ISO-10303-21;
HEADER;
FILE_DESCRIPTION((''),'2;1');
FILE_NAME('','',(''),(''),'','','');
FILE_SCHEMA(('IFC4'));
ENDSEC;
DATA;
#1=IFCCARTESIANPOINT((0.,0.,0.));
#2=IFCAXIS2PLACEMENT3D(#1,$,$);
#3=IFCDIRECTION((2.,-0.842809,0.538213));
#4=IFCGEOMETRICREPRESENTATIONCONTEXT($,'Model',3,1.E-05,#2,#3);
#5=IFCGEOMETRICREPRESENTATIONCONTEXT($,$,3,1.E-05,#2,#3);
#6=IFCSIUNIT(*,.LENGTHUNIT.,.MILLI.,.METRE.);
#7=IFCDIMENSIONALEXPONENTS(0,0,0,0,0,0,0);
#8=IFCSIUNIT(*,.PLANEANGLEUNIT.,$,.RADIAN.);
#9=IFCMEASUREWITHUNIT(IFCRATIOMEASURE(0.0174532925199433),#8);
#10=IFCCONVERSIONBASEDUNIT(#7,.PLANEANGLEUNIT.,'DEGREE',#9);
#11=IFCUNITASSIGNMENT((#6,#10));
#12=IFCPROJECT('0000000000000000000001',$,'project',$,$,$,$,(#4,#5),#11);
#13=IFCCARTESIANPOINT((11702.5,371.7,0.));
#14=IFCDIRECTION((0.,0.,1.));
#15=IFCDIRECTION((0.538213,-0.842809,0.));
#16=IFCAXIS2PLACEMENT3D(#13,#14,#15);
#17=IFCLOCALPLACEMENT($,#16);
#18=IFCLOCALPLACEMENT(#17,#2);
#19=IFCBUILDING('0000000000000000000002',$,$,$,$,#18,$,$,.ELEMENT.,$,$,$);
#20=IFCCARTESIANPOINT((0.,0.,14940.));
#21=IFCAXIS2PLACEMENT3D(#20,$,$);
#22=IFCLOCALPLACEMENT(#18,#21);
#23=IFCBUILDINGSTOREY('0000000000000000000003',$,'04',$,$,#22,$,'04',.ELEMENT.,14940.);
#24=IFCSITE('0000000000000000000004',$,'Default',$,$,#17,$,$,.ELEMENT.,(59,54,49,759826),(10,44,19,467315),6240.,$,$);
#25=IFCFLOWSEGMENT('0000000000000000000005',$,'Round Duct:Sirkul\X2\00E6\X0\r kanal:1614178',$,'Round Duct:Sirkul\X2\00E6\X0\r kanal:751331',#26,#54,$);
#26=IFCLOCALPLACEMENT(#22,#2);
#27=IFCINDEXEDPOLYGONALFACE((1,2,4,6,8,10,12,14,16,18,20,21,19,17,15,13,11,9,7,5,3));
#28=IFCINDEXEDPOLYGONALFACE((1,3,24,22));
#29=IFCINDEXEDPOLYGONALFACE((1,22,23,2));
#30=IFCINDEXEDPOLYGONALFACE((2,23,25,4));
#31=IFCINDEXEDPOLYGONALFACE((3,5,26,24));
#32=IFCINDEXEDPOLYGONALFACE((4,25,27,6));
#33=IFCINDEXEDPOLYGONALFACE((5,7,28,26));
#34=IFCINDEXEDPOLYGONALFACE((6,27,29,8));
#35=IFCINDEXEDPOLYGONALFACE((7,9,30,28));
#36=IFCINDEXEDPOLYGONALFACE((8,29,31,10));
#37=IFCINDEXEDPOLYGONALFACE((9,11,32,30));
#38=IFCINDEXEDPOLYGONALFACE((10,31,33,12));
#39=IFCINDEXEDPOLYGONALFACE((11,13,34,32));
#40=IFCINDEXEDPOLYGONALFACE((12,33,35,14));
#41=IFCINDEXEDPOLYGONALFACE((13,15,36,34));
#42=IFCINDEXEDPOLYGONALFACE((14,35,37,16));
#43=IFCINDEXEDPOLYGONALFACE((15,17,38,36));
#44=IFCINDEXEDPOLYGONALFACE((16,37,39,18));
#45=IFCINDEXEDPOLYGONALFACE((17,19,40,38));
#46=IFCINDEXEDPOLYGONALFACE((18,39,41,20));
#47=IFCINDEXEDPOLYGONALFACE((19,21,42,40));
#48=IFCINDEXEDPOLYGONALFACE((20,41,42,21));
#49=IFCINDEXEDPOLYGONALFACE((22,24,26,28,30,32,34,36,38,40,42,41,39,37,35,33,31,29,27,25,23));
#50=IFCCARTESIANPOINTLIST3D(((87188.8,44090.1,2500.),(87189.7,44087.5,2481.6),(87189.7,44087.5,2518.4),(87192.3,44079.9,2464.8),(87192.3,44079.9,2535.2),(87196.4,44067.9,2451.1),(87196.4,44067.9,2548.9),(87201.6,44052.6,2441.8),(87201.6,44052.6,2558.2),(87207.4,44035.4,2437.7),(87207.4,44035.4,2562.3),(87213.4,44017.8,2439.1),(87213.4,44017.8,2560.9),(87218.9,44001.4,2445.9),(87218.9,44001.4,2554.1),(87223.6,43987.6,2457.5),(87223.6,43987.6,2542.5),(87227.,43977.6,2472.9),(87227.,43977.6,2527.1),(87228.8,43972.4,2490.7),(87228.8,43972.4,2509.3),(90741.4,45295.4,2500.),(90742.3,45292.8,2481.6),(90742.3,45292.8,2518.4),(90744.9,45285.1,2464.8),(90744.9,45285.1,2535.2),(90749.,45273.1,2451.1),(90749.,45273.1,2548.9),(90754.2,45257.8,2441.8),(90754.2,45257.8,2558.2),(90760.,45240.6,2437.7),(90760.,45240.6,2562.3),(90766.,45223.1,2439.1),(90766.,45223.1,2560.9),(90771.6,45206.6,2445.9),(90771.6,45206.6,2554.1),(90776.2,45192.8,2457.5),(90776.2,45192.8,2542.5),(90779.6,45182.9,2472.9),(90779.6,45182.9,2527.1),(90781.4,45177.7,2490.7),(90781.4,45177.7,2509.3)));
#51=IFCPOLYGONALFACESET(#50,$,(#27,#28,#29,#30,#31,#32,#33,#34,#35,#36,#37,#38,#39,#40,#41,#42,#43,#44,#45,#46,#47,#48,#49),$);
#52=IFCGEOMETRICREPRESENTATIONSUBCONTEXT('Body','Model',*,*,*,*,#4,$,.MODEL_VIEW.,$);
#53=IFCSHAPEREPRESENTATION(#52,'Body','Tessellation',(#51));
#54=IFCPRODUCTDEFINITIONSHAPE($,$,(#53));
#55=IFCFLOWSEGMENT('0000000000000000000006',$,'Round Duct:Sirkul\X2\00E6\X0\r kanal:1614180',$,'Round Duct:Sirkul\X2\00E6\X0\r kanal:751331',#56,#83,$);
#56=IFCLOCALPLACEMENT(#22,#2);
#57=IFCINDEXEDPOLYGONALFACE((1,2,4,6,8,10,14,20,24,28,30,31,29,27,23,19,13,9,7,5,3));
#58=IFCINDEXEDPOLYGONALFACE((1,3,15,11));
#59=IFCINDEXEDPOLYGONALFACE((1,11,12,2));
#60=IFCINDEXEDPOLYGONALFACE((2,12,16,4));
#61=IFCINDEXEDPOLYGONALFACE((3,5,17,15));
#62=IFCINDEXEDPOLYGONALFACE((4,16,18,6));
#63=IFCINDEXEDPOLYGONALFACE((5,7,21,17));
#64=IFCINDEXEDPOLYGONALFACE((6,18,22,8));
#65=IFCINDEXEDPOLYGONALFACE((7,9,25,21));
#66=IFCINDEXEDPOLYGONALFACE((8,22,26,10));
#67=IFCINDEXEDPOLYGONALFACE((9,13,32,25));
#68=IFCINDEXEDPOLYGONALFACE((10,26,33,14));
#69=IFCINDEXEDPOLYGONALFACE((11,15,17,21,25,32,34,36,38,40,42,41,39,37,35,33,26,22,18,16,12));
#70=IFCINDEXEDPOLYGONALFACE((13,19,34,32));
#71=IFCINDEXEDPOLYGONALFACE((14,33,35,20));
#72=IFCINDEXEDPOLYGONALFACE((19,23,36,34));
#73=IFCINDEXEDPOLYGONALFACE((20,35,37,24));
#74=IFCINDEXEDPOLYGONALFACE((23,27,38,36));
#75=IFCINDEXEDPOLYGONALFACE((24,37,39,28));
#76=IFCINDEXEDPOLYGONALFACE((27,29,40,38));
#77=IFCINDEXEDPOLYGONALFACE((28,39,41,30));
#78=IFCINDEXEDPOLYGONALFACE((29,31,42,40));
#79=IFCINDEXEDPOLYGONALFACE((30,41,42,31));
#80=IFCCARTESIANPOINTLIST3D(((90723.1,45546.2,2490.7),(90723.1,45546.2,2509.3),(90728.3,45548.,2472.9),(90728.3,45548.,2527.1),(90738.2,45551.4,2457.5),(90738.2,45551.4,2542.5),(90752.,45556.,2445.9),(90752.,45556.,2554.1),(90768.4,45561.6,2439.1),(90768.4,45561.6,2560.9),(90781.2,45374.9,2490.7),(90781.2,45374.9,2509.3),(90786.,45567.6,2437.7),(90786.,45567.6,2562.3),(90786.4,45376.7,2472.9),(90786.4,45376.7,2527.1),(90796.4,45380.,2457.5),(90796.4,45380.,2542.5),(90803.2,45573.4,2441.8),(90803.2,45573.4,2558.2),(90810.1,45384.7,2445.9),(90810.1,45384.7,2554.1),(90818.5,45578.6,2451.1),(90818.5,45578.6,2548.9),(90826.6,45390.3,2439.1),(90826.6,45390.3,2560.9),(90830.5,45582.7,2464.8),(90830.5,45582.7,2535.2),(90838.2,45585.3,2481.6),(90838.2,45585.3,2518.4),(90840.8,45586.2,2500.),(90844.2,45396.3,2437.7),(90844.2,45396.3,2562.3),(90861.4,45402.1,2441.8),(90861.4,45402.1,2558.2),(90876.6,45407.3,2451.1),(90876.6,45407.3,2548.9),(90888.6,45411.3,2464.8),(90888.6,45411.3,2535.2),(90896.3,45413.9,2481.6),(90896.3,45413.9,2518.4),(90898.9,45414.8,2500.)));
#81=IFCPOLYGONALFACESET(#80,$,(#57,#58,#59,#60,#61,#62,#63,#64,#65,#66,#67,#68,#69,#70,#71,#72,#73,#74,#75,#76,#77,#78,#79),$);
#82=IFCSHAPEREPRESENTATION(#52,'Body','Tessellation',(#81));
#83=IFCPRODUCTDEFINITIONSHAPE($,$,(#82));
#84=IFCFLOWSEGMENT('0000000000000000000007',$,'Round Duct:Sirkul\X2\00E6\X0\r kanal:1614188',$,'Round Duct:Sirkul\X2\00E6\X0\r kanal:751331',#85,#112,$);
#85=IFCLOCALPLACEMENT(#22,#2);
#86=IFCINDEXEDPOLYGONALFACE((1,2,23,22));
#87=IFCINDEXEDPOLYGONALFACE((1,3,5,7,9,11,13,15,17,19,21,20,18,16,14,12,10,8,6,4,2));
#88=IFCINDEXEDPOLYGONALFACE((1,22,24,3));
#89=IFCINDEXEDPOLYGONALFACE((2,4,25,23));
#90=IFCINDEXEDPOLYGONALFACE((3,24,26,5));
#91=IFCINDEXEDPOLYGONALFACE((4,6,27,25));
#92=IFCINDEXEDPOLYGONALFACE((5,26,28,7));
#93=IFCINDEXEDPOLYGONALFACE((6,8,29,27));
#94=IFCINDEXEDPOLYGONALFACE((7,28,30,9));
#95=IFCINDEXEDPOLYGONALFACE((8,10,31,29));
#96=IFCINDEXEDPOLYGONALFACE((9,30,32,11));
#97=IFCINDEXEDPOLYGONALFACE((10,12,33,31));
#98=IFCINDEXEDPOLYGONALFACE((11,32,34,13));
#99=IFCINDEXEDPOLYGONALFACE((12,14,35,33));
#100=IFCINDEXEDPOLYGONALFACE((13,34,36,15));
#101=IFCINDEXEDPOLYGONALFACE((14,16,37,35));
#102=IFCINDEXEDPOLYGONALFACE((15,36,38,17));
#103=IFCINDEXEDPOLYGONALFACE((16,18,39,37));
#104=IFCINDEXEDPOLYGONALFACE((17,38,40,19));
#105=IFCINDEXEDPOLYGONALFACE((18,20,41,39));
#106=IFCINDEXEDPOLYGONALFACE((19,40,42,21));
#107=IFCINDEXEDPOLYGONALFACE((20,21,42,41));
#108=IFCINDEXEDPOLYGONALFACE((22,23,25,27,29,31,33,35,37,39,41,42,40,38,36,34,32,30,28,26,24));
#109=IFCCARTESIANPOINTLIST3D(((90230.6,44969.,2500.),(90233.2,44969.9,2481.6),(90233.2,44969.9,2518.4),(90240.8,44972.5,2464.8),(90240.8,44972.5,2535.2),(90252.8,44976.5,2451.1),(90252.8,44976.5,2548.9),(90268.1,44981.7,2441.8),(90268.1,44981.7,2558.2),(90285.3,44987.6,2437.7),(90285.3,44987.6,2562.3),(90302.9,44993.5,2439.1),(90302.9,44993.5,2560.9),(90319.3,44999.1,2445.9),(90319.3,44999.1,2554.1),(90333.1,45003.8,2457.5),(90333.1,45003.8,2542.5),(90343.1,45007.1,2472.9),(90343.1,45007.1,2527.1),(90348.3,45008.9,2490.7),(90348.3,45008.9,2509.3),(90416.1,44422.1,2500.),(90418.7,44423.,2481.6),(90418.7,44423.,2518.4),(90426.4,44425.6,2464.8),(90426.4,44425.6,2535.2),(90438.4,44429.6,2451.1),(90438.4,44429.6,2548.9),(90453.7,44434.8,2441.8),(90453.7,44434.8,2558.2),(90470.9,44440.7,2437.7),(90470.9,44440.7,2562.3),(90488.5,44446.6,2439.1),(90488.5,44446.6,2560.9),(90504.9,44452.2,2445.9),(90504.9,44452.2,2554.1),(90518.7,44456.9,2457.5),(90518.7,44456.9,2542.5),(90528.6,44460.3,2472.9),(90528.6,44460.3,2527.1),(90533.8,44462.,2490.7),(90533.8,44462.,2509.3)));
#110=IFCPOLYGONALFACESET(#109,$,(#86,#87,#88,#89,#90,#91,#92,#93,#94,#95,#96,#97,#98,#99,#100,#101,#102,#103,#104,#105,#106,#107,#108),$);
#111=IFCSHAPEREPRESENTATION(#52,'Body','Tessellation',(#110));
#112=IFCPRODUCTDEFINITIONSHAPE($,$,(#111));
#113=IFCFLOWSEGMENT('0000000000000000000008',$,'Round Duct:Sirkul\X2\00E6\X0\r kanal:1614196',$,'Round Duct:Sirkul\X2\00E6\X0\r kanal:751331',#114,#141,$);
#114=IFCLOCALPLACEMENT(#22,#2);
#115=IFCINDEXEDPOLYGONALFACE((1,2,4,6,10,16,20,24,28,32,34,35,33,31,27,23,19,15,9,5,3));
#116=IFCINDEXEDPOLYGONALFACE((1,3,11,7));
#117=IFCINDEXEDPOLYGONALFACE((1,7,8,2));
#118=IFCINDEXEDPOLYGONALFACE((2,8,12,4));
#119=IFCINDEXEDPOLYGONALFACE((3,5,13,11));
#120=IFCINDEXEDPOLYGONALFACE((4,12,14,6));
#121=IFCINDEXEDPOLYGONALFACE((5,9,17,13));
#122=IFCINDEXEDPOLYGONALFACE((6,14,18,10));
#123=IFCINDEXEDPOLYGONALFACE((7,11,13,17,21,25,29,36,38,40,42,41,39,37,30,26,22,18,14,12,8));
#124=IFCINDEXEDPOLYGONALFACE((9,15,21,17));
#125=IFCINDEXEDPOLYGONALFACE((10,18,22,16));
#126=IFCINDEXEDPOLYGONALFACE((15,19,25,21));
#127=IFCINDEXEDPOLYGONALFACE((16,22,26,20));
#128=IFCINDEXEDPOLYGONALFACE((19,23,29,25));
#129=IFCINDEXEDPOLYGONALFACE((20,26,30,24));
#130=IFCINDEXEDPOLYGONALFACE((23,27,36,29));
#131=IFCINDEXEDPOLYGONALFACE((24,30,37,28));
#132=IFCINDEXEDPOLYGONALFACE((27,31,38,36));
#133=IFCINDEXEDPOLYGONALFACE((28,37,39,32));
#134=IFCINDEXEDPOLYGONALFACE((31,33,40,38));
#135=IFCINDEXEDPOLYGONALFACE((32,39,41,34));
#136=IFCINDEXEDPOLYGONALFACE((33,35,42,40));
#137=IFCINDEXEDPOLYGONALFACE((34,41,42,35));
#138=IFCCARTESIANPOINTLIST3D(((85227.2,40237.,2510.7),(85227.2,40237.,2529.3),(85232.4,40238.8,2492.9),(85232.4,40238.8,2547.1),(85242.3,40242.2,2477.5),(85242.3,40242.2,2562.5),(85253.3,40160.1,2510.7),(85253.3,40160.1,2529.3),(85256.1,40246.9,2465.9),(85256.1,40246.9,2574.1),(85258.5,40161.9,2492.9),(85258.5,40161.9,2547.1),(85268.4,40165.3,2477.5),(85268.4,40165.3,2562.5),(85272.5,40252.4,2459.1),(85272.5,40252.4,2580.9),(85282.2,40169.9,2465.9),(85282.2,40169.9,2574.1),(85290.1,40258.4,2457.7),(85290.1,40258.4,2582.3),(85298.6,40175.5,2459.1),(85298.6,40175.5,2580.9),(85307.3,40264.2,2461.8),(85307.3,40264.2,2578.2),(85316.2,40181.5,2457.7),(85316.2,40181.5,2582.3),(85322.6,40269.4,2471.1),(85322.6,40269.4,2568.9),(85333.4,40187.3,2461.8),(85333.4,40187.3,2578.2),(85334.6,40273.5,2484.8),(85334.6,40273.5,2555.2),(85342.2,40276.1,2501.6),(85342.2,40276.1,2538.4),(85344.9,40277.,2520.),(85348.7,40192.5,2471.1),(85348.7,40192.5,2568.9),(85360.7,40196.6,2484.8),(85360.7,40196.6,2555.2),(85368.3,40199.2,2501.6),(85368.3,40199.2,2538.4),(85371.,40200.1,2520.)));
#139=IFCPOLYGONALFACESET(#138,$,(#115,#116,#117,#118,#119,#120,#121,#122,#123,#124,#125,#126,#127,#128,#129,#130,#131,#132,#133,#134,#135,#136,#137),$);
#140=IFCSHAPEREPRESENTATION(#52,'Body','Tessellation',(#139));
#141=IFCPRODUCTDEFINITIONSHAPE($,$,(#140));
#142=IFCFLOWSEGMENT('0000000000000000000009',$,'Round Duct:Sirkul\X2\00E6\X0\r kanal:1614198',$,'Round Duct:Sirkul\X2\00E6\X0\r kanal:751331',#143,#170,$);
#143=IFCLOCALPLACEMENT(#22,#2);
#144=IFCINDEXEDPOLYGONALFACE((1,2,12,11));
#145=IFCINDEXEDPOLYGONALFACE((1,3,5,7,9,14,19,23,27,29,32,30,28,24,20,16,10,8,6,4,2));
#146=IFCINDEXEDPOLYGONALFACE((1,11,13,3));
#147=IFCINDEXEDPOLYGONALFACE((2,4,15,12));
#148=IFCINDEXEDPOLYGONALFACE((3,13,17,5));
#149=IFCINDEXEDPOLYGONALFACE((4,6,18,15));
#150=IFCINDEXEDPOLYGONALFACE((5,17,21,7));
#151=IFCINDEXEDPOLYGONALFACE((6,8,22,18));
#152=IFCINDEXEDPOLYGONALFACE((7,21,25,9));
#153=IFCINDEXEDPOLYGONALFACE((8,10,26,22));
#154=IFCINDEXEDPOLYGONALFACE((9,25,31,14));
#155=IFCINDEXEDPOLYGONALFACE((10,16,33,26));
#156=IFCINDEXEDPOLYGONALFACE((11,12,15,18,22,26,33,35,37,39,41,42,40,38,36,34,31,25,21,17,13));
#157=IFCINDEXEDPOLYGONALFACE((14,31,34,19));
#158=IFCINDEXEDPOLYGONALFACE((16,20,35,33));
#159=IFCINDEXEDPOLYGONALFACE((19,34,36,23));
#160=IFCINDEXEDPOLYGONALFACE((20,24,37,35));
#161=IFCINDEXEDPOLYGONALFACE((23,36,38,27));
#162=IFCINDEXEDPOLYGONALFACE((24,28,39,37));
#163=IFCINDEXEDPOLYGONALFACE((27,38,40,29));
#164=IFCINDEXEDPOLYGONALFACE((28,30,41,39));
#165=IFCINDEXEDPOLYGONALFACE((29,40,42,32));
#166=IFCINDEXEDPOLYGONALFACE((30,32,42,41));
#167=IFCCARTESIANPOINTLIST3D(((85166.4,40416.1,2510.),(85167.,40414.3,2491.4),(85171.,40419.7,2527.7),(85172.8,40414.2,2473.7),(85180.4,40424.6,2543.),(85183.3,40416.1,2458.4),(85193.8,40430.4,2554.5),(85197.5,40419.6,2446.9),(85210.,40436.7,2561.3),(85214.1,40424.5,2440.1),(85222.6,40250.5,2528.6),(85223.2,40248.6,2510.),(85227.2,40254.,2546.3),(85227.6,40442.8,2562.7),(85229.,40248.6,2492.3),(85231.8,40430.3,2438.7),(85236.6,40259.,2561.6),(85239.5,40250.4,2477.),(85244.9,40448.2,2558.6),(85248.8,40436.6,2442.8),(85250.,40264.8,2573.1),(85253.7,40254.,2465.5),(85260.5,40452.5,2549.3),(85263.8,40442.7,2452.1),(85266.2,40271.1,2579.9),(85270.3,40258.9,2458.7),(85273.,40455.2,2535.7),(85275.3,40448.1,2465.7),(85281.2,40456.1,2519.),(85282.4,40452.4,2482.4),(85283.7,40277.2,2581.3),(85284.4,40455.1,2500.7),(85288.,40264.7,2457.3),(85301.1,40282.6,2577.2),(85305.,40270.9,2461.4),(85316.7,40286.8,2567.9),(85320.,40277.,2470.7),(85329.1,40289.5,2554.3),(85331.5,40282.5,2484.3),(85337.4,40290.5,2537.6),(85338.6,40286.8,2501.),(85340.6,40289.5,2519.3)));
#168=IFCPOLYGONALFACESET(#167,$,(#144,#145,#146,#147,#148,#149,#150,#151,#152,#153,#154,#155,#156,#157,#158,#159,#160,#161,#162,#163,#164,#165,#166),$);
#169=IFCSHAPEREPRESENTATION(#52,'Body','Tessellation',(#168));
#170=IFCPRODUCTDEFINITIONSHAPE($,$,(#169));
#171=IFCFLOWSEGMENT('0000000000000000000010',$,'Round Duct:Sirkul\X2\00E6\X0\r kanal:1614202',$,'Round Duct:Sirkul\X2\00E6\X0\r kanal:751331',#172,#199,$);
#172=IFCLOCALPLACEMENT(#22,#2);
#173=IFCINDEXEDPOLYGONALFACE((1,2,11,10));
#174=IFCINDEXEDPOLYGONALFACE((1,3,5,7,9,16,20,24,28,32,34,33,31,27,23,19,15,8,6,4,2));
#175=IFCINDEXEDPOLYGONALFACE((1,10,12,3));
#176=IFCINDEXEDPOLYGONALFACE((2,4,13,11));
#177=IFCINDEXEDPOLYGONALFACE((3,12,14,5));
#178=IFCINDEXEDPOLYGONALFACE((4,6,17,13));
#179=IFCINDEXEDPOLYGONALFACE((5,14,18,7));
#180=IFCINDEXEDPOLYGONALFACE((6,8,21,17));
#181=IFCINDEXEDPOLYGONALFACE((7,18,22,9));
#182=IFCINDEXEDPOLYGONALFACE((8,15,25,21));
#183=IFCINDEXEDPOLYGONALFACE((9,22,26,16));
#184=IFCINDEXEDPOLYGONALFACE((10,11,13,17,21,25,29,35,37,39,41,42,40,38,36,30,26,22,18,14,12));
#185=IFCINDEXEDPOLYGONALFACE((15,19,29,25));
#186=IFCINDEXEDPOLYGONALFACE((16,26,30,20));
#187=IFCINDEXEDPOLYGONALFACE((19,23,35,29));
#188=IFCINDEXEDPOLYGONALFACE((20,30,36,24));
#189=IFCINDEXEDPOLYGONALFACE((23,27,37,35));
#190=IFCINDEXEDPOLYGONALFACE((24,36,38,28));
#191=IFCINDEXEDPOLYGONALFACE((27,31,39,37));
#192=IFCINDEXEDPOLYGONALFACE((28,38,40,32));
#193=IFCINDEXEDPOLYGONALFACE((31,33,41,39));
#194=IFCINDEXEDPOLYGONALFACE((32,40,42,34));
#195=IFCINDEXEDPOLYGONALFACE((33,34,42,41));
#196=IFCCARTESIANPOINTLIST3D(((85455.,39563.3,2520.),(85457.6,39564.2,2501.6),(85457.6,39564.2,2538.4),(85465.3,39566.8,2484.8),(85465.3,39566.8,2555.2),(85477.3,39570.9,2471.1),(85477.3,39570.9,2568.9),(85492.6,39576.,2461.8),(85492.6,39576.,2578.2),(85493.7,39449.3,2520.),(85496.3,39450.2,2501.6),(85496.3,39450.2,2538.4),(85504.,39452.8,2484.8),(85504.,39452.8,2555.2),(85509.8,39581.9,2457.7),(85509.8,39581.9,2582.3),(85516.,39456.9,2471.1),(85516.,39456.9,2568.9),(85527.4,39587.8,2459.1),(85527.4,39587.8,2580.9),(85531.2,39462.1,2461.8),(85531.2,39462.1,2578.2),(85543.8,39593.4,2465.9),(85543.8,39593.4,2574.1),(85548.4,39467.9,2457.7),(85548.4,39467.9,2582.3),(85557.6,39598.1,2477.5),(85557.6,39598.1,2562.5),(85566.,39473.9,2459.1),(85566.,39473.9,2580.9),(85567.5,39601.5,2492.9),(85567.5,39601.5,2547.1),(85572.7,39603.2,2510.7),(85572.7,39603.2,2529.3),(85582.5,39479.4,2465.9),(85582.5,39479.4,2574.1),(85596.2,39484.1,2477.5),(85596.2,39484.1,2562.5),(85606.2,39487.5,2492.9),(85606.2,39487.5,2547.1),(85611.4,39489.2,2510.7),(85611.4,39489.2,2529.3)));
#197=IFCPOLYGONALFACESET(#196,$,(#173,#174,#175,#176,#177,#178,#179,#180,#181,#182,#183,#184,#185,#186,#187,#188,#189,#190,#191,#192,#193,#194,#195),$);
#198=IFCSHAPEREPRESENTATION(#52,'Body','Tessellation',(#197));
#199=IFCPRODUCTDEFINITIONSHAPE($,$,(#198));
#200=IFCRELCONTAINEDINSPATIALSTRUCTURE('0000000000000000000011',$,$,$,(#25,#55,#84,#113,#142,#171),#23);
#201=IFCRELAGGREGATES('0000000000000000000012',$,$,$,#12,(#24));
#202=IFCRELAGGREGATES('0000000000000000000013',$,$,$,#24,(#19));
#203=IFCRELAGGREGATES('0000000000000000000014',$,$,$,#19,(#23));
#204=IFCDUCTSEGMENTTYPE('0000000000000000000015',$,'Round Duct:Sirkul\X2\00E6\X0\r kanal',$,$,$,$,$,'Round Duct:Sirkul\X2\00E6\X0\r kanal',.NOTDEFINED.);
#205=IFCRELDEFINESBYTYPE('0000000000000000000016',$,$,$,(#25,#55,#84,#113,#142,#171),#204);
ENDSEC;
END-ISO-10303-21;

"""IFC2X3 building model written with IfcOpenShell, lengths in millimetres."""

from ifc_helpers import new_model, entity, si_unit, converted_unit, direction, frame, frame_2d, origin, origin_2d_with_axis, place, context, subcontext, project, spatial, circle, extrude, type_object, element, save


model = new_model("IFC2X3")

# Units and contexts
model_context = context("Model", 3, precision=1e-05, world=origin(), true_north=direction((2.0, -0.842809, 0.538213)))
context_of_model = context(None, 3, precision=1e-05, world=origin(), true_north=direction((2.0, -0.842809, 0.538213)))
body_context = subcontext(model_context, "Body", "Model", "MODEL_VIEW")
ifc_project = project(units=[si_unit("LENGTHUNIT", "METRE", prefix="MILLI"), converted_unit("PLANEANGLEUNIT", "DEGREE", entity("IfcRatioMeasure", 0.0174532925199433), si_unit("PLANEANGLEUNIT", "RADIAN"), dimensions=[0, 0, 0, 0, 0, 0, 0])], contexts=[model_context, context_of_model])

# Site, building, storey
site_placement = place(None, frame((11702.5, 371.7, 0.0), z_axis=(0.0, 0.0, 1.0), x_axis=(0.538213, -0.842809, 0.0)))
site = spatial("IfcSite", under=ifc_project, at=site_placement, Name="Default", CompositionType="ELEMENT", RefLatitude=(59, 54, 49, 759826), RefLongitude=(10, 44, 19, 467315), RefElevation=6240.0)
building_placement = place(site_placement, origin())
building = spatial("IfcBuilding", under=site, at=building_placement, CompositionType="ELEMENT")
storey_placement = place(building_placement, frame((0.0, 0.0, 14940.0)))
storey = spatial("IfcBuildingStorey", under=building, at=storey_placement, Name="04", LongName="04", CompositionType="ELEMENT", Elevation=14940.0)

# Flow segments
duct_segment_type = type_object("IfcDuctSegmentType", Name="Round Duct:Sirkulær kanal", ElementType="Round Duct:Sirkulær kanal", PredefinedType="NOTDEFINED")
flow_segment_1_placement = place(storey_placement, origin())
element("IfcFlowSegment", 1, at=flow_segment_1_placement, inside=storey, type_object=duct_segment_type, Name="Round Duct:Sirkulær kanal:1614178", ObjectType="Round Duct:Sirkulær kanal:751331", context=body_context, shape_type="SweptSolid", body=[
    extrude(circle(Radius=62.5, at=frame_2d((0.0, 0.0), x_axis=(1.0, 0.0))), frame((90761.5, 45236.2, 2500.0), z_axis=(-0.946986, -0.321274, 0.000003), x_axis=(-0.321274, 0.946986, 0.0)), (0.0, 0.0, 1.0), 3751.5),
])
flow_segment_2_placement = place(storey_placement, origin())
element("IfcFlowSegment", 2, at=flow_segment_2_placement, inside=storey, type_object=duct_segment_type, Name="Round Duct:Sirkulær kanal:1614180", ObjectType="Round Duct:Sirkulær kanal:751331", context=body_context, shape_type="SweptSolid", body=[
    extrude(circle(Radius=62.5, at=origin_2d_with_axis()), frame((90839.7, 45394.8, 2500.0), z_axis=(-0.321274, 0.946986, 0.0), x_axis=(0.946986, 0.321274, 0.0)), (0.0, 0.0, 1.0), 180.9),
])
flow_segment_3_placement = place(storey_placement, origin())
element("IfcFlowSegment", 3, at=flow_segment_3_placement, inside=storey, type_object=duct_segment_type, Name="Round Duct:Sirkulær kanal:1614188", ObjectType="Round Duct:Sirkulær kanal:751331", context=body_context, shape_type="SweptSolid", body=[
    extrude(circle(Radius=62.5, at=frame_2d((0.0, 0.0), x_axis=(1.0, 0.0))), frame((90289.7, 44989.1, 2500.0), z_axis=(0.321274, -0.946986, 0.0), x_axis=(-0.946986, -0.321274, 0.0)), (0.0, 0.0, 1.0), 577.5),
])
flow_segment_4_placement = place(storey_placement, origin())
element("IfcFlowSegment", 4, at=flow_segment_4_placement, inside=storey, type_object=duct_segment_type, Name="Round Duct:Sirkulær kanal:1614196", ObjectType="Round Duct:Sirkulær kanal:751331", context=body_context, shape_type="SweptSolid", body=[
    extrude(circle(Radius=62.5, at=frame_2d((0.0, 0.0), x_axis=(1.0, 0.0))), frame((85285.7, 40256.9, 2520.0), z_axis=(0.321274, -0.946986, 0.0), x_axis=(0.946986, 0.321274, 0.0)), (0.0, 0.0, 1.0), 81.2),
])
flow_segment_5_placement = place(storey_placement, origin())
element("IfcFlowSegment", 5, at=flow_segment_5_placement, inside=storey, type_object=duct_segment_type, Name="Round Duct:Sirkulær kanal:1614198", ObjectType="Round Duct:Sirkulær kanal:751331", context=body_context, shape_type="SweptSolid", body=[
    extrude(circle(Radius=62.5, at=frame_2d((0.0, 0.0), x_axis=(1.0, 0.0))), frame((85225.2, 40435.0, 2500.7), z_axis=(0.319473, -0.941677, 0.105746), x_axis=(0.946986, 0.321274, 0.0)), (0.0, 0.0, 1.0), 175.9),
])
flow_segment_6_placement = place(storey_placement, origin())
element("IfcFlowSegment", 6, at=flow_segment_6_placement, inside=storey, type_object=duct_segment_type, Name="Round Duct:Sirkulær kanal:1614202", ObjectType="Round Duct:Sirkulær kanal:751331", context=body_context, shape_type="SweptSolid", body=[
    extrude(circle(Radius=62.5, at=origin_2d_with_axis()), frame((85552.9, 39469.4, 2520.0), z_axis=(-0.321274, 0.946986, 0.0), x_axis=(-0.946986, -0.321274, 0.0)), (0.0, 0.0, 1.0), 120.4),
])

save(model, "model.ifc")
